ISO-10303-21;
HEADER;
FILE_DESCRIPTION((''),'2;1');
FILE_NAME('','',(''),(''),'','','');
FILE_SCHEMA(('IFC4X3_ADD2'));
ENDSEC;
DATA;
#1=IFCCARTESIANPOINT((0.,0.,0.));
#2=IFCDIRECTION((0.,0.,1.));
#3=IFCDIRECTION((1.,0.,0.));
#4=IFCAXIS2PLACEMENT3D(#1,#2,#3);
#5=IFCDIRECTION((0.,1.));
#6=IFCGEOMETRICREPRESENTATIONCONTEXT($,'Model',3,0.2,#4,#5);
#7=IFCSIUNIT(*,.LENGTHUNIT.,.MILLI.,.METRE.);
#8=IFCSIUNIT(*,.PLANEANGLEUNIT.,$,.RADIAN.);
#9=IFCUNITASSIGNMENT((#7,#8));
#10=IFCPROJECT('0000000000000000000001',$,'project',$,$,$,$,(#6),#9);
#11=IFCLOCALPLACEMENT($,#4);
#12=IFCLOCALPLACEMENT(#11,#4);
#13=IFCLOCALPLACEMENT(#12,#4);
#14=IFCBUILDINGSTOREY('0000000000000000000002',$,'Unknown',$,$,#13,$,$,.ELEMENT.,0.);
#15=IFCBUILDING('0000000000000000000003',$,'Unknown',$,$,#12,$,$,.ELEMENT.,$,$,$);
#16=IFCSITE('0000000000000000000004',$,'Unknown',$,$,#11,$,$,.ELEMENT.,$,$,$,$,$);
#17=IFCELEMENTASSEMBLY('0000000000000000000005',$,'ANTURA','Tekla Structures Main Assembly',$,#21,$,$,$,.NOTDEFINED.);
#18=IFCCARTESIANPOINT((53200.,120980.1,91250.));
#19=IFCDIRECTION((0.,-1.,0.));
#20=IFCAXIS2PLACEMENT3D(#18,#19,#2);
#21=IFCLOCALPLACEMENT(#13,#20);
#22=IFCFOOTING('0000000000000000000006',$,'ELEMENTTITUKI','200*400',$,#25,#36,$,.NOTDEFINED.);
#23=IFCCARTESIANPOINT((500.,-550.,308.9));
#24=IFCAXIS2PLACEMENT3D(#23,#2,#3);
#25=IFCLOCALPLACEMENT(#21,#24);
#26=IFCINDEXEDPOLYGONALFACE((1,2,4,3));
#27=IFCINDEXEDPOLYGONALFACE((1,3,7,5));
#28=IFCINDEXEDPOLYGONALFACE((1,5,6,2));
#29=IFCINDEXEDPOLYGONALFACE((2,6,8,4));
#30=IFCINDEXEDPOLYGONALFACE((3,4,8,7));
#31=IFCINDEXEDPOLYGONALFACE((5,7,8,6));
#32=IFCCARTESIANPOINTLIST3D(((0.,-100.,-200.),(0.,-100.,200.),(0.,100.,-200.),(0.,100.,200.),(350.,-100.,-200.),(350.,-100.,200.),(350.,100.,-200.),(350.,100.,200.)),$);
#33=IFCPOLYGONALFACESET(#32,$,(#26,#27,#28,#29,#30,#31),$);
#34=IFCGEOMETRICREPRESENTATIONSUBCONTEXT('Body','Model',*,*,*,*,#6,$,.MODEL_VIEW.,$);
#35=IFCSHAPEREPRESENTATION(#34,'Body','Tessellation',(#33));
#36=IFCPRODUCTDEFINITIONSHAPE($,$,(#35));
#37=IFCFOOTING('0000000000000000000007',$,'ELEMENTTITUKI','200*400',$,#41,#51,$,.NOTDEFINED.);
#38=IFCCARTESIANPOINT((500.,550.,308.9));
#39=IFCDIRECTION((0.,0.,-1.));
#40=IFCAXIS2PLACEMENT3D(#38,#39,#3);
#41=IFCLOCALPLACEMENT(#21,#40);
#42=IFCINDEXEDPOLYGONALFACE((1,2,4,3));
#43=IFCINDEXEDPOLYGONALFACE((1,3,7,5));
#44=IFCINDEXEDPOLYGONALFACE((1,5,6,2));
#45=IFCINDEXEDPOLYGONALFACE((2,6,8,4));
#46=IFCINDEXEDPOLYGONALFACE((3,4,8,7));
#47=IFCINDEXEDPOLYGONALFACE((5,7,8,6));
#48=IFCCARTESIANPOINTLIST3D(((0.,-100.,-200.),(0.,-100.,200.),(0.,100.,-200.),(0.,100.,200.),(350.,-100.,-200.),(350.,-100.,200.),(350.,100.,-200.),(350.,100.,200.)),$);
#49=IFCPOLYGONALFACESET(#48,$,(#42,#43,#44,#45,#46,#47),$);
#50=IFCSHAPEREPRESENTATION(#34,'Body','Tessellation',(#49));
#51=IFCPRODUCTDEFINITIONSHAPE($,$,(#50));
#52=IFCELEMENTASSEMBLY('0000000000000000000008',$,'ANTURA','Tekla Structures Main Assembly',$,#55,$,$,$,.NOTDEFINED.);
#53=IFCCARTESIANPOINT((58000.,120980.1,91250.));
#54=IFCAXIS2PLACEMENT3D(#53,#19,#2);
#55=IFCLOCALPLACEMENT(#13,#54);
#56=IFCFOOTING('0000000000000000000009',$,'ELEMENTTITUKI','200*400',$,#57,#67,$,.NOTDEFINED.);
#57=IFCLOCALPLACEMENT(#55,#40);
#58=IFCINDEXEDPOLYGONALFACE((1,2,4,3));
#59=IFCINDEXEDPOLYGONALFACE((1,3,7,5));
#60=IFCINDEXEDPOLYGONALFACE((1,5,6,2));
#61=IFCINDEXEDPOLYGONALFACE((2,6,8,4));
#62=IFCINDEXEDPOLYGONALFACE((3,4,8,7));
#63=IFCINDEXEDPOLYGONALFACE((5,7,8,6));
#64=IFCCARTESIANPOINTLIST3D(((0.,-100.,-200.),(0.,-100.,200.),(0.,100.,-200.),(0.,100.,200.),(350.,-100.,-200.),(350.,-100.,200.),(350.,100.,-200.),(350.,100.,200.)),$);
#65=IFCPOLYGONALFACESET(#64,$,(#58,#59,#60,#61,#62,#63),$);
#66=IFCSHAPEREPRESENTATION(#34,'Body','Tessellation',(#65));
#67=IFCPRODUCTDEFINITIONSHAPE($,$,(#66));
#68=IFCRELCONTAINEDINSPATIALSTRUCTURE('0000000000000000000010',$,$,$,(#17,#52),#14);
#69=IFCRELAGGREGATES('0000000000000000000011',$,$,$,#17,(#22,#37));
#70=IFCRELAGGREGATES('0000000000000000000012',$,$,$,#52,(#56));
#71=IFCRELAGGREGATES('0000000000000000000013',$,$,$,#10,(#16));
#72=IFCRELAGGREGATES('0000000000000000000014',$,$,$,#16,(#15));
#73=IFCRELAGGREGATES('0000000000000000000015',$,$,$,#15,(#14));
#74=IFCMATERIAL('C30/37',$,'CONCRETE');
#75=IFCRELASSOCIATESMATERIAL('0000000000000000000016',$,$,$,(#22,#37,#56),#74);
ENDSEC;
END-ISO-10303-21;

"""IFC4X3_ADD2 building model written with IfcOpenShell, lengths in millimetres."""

from ifc_helpers import new_model, si_unit, direction, frame, origin_with_axes, place, context, subcontext, project, spatial, line, indexed_curve, outline, extrude, material, element, aggregate, save


model = new_model("IFC4X3_ADD2")

# Units and contexts
model_context = context("Model", 3, precision=0.2, world=origin_with_axes(), true_north=direction((0.0, 1.0)))
body_context = subcontext(model_context, "Body", "Model", "MODEL_VIEW")
ifc_project = project(units=[si_unit("LENGTHUNIT", "METRE", prefix="MILLI"), si_unit("PLANEANGLEUNIT", "RADIAN")], contexts=[model_context])

# Site, building, storey
site_placement = place(None, origin_with_axes())
site = spatial("IfcSite", under=ifc_project, at=site_placement, Name="Unknown", CompositionType="ELEMENT")
building_placement = place(site_placement, origin_with_axes())
building = spatial("IfcBuilding", under=site, at=building_placement, Name="Unknown", CompositionType="ELEMENT")
storey_placement = place(building_placement, origin_with_axes())
storey = spatial("IfcBuildingStorey", under=building, at=storey_placement, Name="Unknown", CompositionType="ELEMENT", Elevation=0.0)

# Element assembly, footings
assembly_1_placement = place(storey_placement, frame((53200.0, 120980.1, 91250.0), z_axis=(0.0, -1.0, 0.0), x_axis=(0.0, 0.0, 1.0)))
assembly_1 = element("IfcElementAssembly", 1, at=assembly_1_placement, inside=storey, Name="ANTURA", Description="Tekla Structures Main Assembly", PredefinedType="NOTDEFINED")
ifc_material_1 = material(Name="C30/37", Category="CONCRETE")
footing_1_placement = place(assembly_1_placement, frame((500.0, -550.0, 308.9), z_axis=(0.0, 0.0, 1.0), x_axis=(1.0, 0.0, 0.0)))
footing_1 = element("IfcFooting", 2, at=footing_1_placement, material=ifc_material_1, Name="ELEMENTTITUKI", Description="200*400", PredefinedType="NOTDEFINED", context=body_context, shape_type="SolidModel", body=[
    extrude(outline(indexed_curve([(-200.0, -100.0), (200.0, -100.0), (200.0, 100.0), (-200.0, 100.0)], segments=[line(1, 2, 3, 4, 1)])), frame((0.0, 0.0, 0.0), z_axis=(-1.0, 0.0, 0.0), x_axis=(0.0, 0.0, 1.0)), (0.0, 0.0, -1.0), 350.0),
])
footing_2_placement = place(assembly_1_placement, frame((500.0, 550.0, 308.9), z_axis=(0.0, 0.0, -1.0), x_axis=(1.0, 0.0, 0.0)))
footing_2 = element("IfcFooting", 3, at=footing_2_placement, material=ifc_material_1, Name="ELEMENTTITUKI", Description="200*400", PredefinedType="NOTDEFINED", context=body_context, shape_type="SolidModel", body=[
    extrude(outline(indexed_curve([(-200.0, -100.0), (200.0, -100.0), (200.0, 100.0), (-200.0, 100.0)], segments=[line(1, 2, 3, 4, 1)])), frame((0.0, 0.0, 0.0), z_axis=(-1.0, 0.0, 0.0), x_axis=(0.0, 0.0, 1.0)), (0.0, 0.0, -1.0), 350.0),
])
aggregate(assembly_1, [footing_1, footing_2])

# Element assembly, footing
assembly_2_placement = place(storey_placement, frame((58000.0, 120980.1, 91250.0), z_axis=(0.0, -1.0, 0.0), x_axis=(0.0, 0.0, 1.0)))
assembly_2 = element("IfcElementAssembly", 4, at=assembly_2_placement, inside=storey, Name="ANTURA", Description="Tekla Structures Main Assembly", PredefinedType="NOTDEFINED")
footing_3_placement = place(assembly_2_placement, frame((500.0, 550.0, 308.9), z_axis=(0.0, 0.0, -1.0), x_axis=(1.0, 0.0, 0.0)))
footing_3 = element("IfcFooting", 5, at=footing_3_placement, material=ifc_material_1, Name="ELEMENTTITUKI", Description="200*400", PredefinedType="NOTDEFINED", context=body_context, shape_type="SolidModel", body=[
    extrude(outline(indexed_curve([(-200.0, -100.0), (200.0, -100.0), (200.0, 100.0), (-200.0, 100.0)], segments=[line(1, 2, 3, 4, 1)])), frame((0.0, 0.0, 0.0), z_axis=(-1.0, 0.0, 0.0), x_axis=(0.0, 0.0, 1.0)), (0.0, 0.0, -1.0), 350.0),
])
aggregate(assembly_2, [footing_3])

save(model, "model.ifc")
